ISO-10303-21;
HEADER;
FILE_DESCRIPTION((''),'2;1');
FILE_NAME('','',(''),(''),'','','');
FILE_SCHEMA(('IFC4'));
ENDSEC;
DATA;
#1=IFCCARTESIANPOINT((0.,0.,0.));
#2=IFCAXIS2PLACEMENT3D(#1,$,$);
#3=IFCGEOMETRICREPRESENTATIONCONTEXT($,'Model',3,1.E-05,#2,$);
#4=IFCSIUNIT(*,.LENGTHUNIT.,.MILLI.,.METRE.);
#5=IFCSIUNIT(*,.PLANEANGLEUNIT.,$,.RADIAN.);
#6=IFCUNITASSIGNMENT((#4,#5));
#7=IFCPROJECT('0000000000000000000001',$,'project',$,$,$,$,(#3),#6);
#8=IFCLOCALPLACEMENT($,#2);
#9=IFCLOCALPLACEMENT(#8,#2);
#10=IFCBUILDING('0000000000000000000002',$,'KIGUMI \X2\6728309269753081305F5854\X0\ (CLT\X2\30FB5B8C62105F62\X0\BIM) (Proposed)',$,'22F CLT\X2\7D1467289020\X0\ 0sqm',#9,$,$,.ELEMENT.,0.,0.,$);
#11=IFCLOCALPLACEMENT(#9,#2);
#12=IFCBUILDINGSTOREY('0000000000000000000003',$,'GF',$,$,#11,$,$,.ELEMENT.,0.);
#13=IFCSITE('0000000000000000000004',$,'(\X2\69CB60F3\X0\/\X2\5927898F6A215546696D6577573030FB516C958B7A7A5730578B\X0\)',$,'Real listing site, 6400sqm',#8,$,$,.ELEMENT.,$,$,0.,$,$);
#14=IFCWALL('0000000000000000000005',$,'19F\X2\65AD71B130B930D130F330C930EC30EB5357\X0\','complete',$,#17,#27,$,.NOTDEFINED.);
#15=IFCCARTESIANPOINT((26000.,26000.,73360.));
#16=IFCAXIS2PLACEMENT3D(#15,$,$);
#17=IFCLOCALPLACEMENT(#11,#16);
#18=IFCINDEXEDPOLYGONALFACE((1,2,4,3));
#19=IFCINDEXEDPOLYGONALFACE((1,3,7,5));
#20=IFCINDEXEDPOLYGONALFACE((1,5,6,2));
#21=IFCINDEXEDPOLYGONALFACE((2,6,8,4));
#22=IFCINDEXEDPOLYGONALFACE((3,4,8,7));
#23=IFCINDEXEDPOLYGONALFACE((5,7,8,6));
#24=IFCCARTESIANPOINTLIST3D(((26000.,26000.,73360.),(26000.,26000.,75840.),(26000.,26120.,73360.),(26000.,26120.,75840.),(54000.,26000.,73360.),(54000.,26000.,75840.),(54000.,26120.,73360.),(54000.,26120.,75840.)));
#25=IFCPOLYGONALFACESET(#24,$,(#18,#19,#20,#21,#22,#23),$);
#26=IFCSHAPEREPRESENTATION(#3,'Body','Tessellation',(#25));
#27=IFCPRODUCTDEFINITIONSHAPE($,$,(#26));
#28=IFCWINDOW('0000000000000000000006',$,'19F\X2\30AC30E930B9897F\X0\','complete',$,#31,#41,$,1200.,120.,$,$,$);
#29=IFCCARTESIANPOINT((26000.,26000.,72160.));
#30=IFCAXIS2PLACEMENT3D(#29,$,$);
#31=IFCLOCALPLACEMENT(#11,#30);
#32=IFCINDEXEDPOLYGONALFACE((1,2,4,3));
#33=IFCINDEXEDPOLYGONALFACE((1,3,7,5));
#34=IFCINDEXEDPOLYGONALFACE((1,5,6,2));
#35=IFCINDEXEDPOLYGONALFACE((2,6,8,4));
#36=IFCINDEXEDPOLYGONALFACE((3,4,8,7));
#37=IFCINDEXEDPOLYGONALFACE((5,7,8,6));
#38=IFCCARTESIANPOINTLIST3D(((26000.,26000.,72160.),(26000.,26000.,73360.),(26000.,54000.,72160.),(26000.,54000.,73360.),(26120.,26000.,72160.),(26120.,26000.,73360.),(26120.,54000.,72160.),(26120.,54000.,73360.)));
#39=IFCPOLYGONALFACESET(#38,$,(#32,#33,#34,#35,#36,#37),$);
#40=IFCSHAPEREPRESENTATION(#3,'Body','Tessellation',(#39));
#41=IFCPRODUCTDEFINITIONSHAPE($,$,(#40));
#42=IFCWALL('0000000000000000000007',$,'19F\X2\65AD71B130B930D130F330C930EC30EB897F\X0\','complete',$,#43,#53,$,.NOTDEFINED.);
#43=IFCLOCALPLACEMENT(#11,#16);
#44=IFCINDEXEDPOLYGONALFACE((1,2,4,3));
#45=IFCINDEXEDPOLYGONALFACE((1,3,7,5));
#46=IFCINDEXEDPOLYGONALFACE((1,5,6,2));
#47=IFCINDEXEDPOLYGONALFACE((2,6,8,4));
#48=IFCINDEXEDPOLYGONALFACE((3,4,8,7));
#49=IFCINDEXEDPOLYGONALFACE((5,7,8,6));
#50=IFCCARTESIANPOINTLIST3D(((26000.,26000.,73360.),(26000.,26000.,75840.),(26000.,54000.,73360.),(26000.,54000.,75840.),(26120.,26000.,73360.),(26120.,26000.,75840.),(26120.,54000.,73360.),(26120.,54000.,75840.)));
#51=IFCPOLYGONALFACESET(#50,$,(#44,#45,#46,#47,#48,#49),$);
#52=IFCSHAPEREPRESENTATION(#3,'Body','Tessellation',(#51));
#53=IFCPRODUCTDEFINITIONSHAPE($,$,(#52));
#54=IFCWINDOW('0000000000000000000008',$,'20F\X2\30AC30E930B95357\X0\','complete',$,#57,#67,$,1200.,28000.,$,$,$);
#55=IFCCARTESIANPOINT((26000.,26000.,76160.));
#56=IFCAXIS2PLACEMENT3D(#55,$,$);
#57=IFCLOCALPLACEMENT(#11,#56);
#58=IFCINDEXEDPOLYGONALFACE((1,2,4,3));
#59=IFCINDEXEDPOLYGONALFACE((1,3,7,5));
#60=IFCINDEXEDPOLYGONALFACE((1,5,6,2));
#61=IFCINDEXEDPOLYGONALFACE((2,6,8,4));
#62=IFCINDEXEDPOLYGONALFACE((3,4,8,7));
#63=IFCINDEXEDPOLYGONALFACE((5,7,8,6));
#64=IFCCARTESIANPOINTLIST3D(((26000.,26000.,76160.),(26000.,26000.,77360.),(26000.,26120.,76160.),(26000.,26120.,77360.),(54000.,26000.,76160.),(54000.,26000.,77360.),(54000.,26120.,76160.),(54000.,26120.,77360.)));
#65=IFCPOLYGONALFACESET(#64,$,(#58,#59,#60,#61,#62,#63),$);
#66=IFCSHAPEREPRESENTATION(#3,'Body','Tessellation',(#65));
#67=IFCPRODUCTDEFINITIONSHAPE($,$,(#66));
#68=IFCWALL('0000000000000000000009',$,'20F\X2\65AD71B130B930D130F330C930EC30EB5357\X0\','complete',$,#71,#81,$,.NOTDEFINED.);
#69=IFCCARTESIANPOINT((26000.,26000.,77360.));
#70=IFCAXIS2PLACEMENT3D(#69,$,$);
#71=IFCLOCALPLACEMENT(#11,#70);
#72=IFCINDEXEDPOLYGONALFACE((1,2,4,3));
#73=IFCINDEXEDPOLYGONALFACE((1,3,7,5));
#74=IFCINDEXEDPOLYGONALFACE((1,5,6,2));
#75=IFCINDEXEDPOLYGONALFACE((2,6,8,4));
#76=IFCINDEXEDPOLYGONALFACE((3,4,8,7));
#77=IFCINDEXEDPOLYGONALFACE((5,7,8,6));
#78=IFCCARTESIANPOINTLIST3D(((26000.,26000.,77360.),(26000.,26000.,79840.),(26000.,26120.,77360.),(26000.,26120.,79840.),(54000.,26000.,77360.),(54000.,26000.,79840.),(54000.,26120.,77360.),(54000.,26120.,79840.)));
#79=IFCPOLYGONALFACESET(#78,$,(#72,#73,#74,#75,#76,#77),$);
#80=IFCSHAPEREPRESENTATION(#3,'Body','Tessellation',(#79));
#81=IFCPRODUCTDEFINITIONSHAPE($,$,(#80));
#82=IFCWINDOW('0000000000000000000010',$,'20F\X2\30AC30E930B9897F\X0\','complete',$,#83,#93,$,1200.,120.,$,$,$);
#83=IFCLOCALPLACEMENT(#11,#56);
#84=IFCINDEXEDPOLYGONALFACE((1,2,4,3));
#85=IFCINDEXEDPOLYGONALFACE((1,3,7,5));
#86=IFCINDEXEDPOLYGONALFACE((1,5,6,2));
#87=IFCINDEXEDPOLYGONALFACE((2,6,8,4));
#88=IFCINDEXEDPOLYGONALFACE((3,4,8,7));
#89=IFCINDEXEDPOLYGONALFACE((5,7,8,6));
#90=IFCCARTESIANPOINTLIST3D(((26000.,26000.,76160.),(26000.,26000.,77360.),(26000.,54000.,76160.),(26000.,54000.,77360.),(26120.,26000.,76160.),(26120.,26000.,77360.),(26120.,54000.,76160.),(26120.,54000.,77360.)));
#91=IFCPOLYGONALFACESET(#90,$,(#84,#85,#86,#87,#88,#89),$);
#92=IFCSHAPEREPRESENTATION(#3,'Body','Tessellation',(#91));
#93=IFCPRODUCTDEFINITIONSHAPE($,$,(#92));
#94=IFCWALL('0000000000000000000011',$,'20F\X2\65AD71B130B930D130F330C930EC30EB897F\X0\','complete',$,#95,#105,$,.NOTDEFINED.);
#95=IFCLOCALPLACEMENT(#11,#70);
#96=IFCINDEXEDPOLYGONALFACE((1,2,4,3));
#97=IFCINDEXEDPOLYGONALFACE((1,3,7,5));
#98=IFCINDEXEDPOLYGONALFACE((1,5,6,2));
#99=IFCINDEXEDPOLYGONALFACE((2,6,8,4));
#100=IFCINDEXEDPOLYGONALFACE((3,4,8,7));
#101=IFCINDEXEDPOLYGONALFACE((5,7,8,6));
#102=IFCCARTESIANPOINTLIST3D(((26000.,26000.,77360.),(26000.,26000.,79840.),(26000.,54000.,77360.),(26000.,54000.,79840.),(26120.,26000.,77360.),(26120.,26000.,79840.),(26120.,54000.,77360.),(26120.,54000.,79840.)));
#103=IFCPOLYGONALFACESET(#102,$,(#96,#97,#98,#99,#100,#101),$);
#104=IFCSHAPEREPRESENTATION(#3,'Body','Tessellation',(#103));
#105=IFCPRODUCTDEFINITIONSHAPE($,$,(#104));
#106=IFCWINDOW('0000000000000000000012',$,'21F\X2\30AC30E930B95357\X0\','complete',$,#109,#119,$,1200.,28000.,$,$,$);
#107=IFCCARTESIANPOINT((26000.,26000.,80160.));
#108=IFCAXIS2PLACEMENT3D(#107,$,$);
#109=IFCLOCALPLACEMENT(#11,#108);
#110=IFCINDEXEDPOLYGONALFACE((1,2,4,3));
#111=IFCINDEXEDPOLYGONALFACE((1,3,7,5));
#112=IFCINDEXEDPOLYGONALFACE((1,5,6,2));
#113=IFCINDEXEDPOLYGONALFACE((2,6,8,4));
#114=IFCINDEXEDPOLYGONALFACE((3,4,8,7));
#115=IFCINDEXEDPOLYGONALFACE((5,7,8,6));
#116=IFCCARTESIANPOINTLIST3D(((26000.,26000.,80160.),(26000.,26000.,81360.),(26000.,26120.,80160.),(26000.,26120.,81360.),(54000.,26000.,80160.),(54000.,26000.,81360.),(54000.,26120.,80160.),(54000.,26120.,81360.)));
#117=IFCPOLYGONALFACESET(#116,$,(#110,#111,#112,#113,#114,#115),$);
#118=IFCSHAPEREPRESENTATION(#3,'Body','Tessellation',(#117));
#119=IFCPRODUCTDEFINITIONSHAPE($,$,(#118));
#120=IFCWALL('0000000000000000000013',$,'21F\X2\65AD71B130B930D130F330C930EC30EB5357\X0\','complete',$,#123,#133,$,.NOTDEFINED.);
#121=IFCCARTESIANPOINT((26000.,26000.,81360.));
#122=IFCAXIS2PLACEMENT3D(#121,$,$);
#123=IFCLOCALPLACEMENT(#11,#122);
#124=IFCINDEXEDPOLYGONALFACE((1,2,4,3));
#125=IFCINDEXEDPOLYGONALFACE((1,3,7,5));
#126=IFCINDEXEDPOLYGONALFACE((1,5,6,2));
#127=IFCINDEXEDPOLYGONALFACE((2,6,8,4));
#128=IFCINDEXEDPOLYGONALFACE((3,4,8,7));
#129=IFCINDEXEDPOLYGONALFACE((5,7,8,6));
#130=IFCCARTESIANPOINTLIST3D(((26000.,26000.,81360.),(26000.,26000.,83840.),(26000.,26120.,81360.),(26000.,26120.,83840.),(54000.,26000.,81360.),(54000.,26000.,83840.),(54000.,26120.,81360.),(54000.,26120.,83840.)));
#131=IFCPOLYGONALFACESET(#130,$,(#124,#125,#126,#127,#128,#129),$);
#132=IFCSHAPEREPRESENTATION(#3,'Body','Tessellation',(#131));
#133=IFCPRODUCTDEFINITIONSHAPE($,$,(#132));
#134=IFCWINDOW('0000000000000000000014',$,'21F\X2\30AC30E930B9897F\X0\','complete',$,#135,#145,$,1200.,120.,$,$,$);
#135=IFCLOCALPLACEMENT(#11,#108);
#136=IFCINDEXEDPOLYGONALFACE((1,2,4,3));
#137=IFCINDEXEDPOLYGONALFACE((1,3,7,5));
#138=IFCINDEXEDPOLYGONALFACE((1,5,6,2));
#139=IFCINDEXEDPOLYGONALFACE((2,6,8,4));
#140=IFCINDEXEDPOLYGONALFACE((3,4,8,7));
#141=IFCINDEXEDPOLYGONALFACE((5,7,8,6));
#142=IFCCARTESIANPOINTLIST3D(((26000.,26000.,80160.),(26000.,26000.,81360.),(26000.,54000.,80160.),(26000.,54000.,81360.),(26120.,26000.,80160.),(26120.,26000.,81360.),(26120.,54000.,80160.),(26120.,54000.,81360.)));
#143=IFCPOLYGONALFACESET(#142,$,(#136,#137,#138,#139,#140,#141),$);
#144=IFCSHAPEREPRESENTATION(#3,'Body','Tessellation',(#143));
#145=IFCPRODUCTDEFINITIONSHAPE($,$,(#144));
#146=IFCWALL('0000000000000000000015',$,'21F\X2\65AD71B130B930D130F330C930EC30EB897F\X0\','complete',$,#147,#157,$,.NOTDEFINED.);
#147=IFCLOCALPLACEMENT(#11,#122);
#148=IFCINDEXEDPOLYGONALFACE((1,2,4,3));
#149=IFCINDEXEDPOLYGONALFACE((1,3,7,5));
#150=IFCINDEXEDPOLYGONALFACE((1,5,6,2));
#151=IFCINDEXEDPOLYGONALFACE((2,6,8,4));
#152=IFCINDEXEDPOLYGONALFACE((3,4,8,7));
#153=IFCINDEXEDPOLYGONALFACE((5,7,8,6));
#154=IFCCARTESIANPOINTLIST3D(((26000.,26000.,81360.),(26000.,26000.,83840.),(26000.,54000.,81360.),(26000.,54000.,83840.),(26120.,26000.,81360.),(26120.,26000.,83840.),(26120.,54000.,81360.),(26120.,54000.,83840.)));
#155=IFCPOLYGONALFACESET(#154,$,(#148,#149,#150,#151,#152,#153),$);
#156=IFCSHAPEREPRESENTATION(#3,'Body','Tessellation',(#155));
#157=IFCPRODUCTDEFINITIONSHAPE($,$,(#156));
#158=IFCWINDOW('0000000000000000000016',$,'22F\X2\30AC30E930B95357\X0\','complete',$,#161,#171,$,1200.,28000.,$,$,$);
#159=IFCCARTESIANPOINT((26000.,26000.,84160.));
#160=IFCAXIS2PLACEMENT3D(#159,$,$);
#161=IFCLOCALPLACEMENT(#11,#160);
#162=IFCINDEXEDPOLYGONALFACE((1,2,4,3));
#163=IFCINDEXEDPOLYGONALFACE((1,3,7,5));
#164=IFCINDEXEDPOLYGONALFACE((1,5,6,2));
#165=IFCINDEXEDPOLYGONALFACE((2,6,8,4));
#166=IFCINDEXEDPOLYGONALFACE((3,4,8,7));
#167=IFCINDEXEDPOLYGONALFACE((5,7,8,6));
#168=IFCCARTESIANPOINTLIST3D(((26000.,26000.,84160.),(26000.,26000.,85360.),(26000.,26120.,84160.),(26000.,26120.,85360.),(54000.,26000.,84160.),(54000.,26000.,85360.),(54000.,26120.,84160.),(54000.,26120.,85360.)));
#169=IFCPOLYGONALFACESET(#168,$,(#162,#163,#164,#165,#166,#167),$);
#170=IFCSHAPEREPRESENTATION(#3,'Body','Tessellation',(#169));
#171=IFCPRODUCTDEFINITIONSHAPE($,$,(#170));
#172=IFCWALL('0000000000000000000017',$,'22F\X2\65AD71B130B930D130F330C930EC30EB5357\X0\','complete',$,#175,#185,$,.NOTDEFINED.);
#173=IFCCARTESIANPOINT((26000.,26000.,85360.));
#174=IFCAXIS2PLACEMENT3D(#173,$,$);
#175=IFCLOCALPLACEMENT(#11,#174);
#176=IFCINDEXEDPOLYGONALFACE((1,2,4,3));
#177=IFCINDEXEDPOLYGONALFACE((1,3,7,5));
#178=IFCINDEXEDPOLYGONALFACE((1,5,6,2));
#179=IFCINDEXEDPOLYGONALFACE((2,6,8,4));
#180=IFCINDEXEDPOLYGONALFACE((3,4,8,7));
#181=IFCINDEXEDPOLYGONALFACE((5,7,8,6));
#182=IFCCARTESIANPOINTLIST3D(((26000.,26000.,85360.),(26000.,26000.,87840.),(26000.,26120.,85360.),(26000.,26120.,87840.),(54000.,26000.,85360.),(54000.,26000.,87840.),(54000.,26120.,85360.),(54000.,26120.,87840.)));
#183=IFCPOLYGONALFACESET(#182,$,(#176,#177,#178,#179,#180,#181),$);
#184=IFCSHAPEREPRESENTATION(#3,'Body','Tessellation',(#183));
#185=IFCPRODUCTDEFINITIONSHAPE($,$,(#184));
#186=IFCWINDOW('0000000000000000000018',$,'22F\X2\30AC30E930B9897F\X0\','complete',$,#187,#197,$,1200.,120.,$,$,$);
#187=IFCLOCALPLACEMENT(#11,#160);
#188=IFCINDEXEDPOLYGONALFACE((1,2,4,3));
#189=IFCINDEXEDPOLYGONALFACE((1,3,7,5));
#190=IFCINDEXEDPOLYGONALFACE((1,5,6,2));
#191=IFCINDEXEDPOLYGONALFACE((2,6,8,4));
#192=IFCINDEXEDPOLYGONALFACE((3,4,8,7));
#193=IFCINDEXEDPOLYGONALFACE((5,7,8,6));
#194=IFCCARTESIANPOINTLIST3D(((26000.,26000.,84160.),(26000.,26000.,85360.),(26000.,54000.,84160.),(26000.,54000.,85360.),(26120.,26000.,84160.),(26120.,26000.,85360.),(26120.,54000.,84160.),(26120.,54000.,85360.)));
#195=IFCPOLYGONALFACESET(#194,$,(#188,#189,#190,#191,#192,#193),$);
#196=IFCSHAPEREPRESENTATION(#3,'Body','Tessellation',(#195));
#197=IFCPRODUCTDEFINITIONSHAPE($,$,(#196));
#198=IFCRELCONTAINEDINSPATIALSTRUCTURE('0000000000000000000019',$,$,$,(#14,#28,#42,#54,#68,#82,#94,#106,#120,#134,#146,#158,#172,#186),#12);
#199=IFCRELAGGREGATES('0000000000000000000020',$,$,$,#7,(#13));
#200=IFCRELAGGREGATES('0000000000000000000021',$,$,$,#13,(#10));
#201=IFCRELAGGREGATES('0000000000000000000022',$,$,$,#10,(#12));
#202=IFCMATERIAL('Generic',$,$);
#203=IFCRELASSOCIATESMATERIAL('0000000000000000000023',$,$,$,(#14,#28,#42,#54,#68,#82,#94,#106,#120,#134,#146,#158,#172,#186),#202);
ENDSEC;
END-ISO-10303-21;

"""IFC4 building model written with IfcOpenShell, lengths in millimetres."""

from ifc_helpers import new_model, si_unit, frame, frame_2d, origin, place, context, project, spatial, rectangle, extrude, material, element, save


model = new_model("IFC4")

# Units and contexts
model_context = context("Model", 3, precision=1e-05, world=origin())
ifc_project = project(units=[si_unit("LENGTHUNIT", "METRE", prefix="MILLI"), si_unit("PLANEANGLEUNIT", "RADIAN")], contexts=[model_context])

# Site, building, storey
site_placement = place(None, origin())
site = spatial("IfcSite", under=ifc_project, at=site_placement, Name="(構想/大規模商業敷地・公開空地型)", ObjectType="Real listing site, 6400sqm", CompositionType="ELEMENT", RefElevation=0.0)
building_placement = place(site_placement, origin())
building = spatial("IfcBuilding", under=site, at=building_placement, Name="KIGUMI 木を極めた塔 (CLT・完成形BIM) (Proposed)", ObjectType="22F CLT純木造 0sqm", CompositionType="ELEMENT", ElevationOfRefHeight=0.0, ElevationOfTerrain=0.0)
storey_placement = place(building_placement, origin())
storey = spatial("IfcBuildingStorey", under=building, at=storey_placement, Name="GF", CompositionType="ELEMENT", Elevation=0.0)

# Shared definitions
ifc_material = material(Name="Generic")

# Wall
wall_1_placement = place(storey_placement, frame((26000.0, 26000.0, 73360.0)))
element("IfcWall", 1, at=wall_1_placement, inside=storey, material=ifc_material, Name="19F断熱スパンドレル南", Description="complete", PredefinedType="NOTDEFINED", context=model_context, shape_type="SweptSolid", body=[
    extrude(rectangle(XDim=28000.0, YDim=120.0, at=frame_2d((14000.0, 60.0))), frame((26000.0, 26000.0, 73360.0)), (0.0, 0.0, 1.0), 2480.0),
])

# Window
window_1_placement = place(storey_placement, frame((26000.0, 26000.0, 72160.0)))
element("IfcWindow", 2, at=window_1_placement, inside=storey, material=ifc_material, Name="19Fガラス西", Description="complete", OverallHeight=1200.0, OverallWidth=120.0, context=model_context, shape_type="SweptSolid", body=[
    extrude(rectangle(XDim=120.0, YDim=28000.0, at=frame_2d((60.0, 14000.0))), frame((26000.0, 26000.0, 72160.0)), (0.0, 0.0, 1.0), 1200.0),
])

# Wall
wall_2_placement = place(storey_placement, frame((26000.0, 26000.0, 73360.0)))
element("IfcWall", 3, at=wall_2_placement, inside=storey, material=ifc_material, Name="19F断熱スパンドレル西", Description="complete", PredefinedType="NOTDEFINED", context=model_context, shape_type="SweptSolid", body=[
    extrude(rectangle(XDim=120.0, YDim=28000.0, at=frame_2d((60.0, 14000.0))), frame((26000.0, 26000.0, 73360.0)), (0.0, 0.0, 1.0), 2480.0),
])

# Window
window_2_placement = place(storey_placement, frame((26000.0, 26000.0, 76160.0)))
element("IfcWindow", 4, at=window_2_placement, inside=storey, material=ifc_material, Name="20Fガラス南", Description="complete", OverallHeight=1200.0, OverallWidth=28000.0, context=model_context, shape_type="SweptSolid", body=[
    extrude(rectangle(XDim=28000.0, YDim=120.0, at=frame_2d((14000.0, 60.0))), frame((26000.0, 26000.0, 76160.0)), (0.0, 0.0, 1.0), 1200.0),
])

# Wall
wall_3_placement = place(storey_placement, frame((26000.0, 26000.0, 77360.0)))
element("IfcWall", 5, at=wall_3_placement, inside=storey, material=ifc_material, Name="20F断熱スパンドレル南", Description="complete", PredefinedType="NOTDEFINED", context=model_context, shape_type="SweptSolid", body=[
    extrude(rectangle(XDim=28000.0, YDim=120.0, at=frame_2d((14000.0, 60.0))), frame((26000.0, 26000.0, 77360.0)), (0.0, 0.0, 1.0), 2480.0),
])

# Window
window_3_placement = place(storey_placement, frame((26000.0, 26000.0, 76160.0)))
element("IfcWindow", 6, at=window_3_placement, inside=storey, material=ifc_material, Name="20Fガラス西", Description="complete", OverallHeight=1200.0, OverallWidth=120.0, context=model_context, shape_type="SweptSolid", body=[
    extrude(rectangle(XDim=120.0, YDim=28000.0, at=frame_2d((60.0, 14000.0))), frame((26000.0, 26000.0, 76160.0)), (0.0, 0.0, 1.0), 1200.0),
])

# Wall
wall_4_placement = place(storey_placement, frame((26000.0, 26000.0, 77360.0)))
element("IfcWall", 7, at=wall_4_placement, inside=storey, material=ifc_material, Name="20F断熱スパンドレル西", Description="complete", PredefinedType="NOTDEFINED", context=model_context, shape_type="SweptSolid", body=[
    extrude(rectangle(XDim=120.0, YDim=28000.0, at=frame_2d((60.0, 14000.0))), frame((26000.0, 26000.0, 77360.0)), (0.0, 0.0, 1.0), 2480.0),
])

# Window
window_4_placement = place(storey_placement, frame((26000.0, 26000.0, 80160.0)))
element("IfcWindow", 8, at=window_4_placement, inside=storey, material=ifc_material, Name="21Fガラス南", Description="complete", OverallHeight=1200.0, OverallWidth=28000.0, context=model_context, shape_type="SweptSolid", body=[
    extrude(rectangle(XDim=28000.0, YDim=120.0, at=frame_2d((14000.0, 60.0))), frame((26000.0, 26000.0, 80160.0)), (0.0, 0.0, 1.0), 1200.0),
])

# Wall
wall_5_placement = place(storey_placement, frame((26000.0, 26000.0, 81360.0)))
element("IfcWall", 9, at=wall_5_placement, inside=storey, material=ifc_material, Name="21F断熱スパンドレル南", Description="complete", PredefinedType="NOTDEFINED", context=model_context, shape_type="SweptSolid", body=[
    extrude(rectangle(XDim=28000.0, YDim=120.0, at=frame_2d((14000.0, 60.0))), frame((26000.0, 26000.0, 81360.0)), (0.0, 0.0, 1.0), 2480.0),
])

# Window
window_5_placement = place(storey_placement, frame((26000.0, 26000.0, 80160.0)))
element("IfcWindow", 10, at=window_5_placement, inside=storey, material=ifc_material, Name="21Fガラス西", Description="complete", OverallHeight=1200.0, OverallWidth=120.0, context=model_context, shape_type="SweptSolid", body=[
    extrude(rectangle(XDim=120.0, YDim=28000.0, at=frame_2d((60.0, 14000.0))), frame((26000.0, 26000.0, 80160.0)), (0.0, 0.0, 1.0), 1200.0),
])

# Wall
wall_6_placement = place(storey_placement, frame((26000.0, 26000.0, 81360.0)))
element("IfcWall", 11, at=wall_6_placement, inside=storey, material=ifc_material, Name="21F断熱スパンドレル西", Description="complete", PredefinedType="NOTDEFINED", context=model_context, shape_type="SweptSolid", body=[
    extrude(rectangle(XDim=120.0, YDim=28000.0, at=frame_2d((60.0, 14000.0))), frame((26000.0, 26000.0, 81360.0)), (0.0, 0.0, 1.0), 2480.0),
])

# Window
window_6_placement = place(storey_placement, frame((26000.0, 26000.0, 84160.0)))
element("IfcWindow", 12, at=window_6_placement, inside=storey, material=ifc_material, Name="22Fガラス南", Description="complete", OverallHeight=1200.0, OverallWidth=28000.0, context=model_context, shape_type="SweptSolid", body=[
    extrude(rectangle(XDim=28000.0, YDim=120.0, at=frame_2d((14000.0, 60.0))), frame((26000.0, 26000.0, 84160.0)), (0.0, 0.0, 1.0), 1200.0),
])

# Wall
wall_7_placement = place(storey_placement, frame((26000.0, 26000.0, 85360.0)))
element("IfcWall", 13, at=wall_7_placement, inside=storey, material=ifc_material, Name="22F断熱スパンドレル南", Description="complete", PredefinedType="NOTDEFINED", context=model_context, shape_type="SweptSolid", body=[
    extrude(rectangle(XDim=28000.0, YDim=120.0, at=frame_2d((14000.0, 60.0))), frame((26000.0, 26000.0, 85360.0)), (0.0, 0.0, 1.0), 2480.0),
])

# Window
window_7_placement = place(storey_placement, frame((26000.0, 26000.0, 84160.0)))
element("IfcWindow", 14, at=window_7_placement, inside=storey, material=ifc_material, Name="22Fガラス西", Description="complete", OverallHeight=1200.0, OverallWidth=120.0, context=model_context, shape_type="SweptSolid", body=[
    extrude(rectangle(XDim=120.0, YDim=28000.0, at=frame_2d((60.0, 14000.0))), frame((26000.0, 26000.0, 84160.0)), (0.0, 0.0, 1.0), 1200.0),
])

save(model, "model.ifc")
